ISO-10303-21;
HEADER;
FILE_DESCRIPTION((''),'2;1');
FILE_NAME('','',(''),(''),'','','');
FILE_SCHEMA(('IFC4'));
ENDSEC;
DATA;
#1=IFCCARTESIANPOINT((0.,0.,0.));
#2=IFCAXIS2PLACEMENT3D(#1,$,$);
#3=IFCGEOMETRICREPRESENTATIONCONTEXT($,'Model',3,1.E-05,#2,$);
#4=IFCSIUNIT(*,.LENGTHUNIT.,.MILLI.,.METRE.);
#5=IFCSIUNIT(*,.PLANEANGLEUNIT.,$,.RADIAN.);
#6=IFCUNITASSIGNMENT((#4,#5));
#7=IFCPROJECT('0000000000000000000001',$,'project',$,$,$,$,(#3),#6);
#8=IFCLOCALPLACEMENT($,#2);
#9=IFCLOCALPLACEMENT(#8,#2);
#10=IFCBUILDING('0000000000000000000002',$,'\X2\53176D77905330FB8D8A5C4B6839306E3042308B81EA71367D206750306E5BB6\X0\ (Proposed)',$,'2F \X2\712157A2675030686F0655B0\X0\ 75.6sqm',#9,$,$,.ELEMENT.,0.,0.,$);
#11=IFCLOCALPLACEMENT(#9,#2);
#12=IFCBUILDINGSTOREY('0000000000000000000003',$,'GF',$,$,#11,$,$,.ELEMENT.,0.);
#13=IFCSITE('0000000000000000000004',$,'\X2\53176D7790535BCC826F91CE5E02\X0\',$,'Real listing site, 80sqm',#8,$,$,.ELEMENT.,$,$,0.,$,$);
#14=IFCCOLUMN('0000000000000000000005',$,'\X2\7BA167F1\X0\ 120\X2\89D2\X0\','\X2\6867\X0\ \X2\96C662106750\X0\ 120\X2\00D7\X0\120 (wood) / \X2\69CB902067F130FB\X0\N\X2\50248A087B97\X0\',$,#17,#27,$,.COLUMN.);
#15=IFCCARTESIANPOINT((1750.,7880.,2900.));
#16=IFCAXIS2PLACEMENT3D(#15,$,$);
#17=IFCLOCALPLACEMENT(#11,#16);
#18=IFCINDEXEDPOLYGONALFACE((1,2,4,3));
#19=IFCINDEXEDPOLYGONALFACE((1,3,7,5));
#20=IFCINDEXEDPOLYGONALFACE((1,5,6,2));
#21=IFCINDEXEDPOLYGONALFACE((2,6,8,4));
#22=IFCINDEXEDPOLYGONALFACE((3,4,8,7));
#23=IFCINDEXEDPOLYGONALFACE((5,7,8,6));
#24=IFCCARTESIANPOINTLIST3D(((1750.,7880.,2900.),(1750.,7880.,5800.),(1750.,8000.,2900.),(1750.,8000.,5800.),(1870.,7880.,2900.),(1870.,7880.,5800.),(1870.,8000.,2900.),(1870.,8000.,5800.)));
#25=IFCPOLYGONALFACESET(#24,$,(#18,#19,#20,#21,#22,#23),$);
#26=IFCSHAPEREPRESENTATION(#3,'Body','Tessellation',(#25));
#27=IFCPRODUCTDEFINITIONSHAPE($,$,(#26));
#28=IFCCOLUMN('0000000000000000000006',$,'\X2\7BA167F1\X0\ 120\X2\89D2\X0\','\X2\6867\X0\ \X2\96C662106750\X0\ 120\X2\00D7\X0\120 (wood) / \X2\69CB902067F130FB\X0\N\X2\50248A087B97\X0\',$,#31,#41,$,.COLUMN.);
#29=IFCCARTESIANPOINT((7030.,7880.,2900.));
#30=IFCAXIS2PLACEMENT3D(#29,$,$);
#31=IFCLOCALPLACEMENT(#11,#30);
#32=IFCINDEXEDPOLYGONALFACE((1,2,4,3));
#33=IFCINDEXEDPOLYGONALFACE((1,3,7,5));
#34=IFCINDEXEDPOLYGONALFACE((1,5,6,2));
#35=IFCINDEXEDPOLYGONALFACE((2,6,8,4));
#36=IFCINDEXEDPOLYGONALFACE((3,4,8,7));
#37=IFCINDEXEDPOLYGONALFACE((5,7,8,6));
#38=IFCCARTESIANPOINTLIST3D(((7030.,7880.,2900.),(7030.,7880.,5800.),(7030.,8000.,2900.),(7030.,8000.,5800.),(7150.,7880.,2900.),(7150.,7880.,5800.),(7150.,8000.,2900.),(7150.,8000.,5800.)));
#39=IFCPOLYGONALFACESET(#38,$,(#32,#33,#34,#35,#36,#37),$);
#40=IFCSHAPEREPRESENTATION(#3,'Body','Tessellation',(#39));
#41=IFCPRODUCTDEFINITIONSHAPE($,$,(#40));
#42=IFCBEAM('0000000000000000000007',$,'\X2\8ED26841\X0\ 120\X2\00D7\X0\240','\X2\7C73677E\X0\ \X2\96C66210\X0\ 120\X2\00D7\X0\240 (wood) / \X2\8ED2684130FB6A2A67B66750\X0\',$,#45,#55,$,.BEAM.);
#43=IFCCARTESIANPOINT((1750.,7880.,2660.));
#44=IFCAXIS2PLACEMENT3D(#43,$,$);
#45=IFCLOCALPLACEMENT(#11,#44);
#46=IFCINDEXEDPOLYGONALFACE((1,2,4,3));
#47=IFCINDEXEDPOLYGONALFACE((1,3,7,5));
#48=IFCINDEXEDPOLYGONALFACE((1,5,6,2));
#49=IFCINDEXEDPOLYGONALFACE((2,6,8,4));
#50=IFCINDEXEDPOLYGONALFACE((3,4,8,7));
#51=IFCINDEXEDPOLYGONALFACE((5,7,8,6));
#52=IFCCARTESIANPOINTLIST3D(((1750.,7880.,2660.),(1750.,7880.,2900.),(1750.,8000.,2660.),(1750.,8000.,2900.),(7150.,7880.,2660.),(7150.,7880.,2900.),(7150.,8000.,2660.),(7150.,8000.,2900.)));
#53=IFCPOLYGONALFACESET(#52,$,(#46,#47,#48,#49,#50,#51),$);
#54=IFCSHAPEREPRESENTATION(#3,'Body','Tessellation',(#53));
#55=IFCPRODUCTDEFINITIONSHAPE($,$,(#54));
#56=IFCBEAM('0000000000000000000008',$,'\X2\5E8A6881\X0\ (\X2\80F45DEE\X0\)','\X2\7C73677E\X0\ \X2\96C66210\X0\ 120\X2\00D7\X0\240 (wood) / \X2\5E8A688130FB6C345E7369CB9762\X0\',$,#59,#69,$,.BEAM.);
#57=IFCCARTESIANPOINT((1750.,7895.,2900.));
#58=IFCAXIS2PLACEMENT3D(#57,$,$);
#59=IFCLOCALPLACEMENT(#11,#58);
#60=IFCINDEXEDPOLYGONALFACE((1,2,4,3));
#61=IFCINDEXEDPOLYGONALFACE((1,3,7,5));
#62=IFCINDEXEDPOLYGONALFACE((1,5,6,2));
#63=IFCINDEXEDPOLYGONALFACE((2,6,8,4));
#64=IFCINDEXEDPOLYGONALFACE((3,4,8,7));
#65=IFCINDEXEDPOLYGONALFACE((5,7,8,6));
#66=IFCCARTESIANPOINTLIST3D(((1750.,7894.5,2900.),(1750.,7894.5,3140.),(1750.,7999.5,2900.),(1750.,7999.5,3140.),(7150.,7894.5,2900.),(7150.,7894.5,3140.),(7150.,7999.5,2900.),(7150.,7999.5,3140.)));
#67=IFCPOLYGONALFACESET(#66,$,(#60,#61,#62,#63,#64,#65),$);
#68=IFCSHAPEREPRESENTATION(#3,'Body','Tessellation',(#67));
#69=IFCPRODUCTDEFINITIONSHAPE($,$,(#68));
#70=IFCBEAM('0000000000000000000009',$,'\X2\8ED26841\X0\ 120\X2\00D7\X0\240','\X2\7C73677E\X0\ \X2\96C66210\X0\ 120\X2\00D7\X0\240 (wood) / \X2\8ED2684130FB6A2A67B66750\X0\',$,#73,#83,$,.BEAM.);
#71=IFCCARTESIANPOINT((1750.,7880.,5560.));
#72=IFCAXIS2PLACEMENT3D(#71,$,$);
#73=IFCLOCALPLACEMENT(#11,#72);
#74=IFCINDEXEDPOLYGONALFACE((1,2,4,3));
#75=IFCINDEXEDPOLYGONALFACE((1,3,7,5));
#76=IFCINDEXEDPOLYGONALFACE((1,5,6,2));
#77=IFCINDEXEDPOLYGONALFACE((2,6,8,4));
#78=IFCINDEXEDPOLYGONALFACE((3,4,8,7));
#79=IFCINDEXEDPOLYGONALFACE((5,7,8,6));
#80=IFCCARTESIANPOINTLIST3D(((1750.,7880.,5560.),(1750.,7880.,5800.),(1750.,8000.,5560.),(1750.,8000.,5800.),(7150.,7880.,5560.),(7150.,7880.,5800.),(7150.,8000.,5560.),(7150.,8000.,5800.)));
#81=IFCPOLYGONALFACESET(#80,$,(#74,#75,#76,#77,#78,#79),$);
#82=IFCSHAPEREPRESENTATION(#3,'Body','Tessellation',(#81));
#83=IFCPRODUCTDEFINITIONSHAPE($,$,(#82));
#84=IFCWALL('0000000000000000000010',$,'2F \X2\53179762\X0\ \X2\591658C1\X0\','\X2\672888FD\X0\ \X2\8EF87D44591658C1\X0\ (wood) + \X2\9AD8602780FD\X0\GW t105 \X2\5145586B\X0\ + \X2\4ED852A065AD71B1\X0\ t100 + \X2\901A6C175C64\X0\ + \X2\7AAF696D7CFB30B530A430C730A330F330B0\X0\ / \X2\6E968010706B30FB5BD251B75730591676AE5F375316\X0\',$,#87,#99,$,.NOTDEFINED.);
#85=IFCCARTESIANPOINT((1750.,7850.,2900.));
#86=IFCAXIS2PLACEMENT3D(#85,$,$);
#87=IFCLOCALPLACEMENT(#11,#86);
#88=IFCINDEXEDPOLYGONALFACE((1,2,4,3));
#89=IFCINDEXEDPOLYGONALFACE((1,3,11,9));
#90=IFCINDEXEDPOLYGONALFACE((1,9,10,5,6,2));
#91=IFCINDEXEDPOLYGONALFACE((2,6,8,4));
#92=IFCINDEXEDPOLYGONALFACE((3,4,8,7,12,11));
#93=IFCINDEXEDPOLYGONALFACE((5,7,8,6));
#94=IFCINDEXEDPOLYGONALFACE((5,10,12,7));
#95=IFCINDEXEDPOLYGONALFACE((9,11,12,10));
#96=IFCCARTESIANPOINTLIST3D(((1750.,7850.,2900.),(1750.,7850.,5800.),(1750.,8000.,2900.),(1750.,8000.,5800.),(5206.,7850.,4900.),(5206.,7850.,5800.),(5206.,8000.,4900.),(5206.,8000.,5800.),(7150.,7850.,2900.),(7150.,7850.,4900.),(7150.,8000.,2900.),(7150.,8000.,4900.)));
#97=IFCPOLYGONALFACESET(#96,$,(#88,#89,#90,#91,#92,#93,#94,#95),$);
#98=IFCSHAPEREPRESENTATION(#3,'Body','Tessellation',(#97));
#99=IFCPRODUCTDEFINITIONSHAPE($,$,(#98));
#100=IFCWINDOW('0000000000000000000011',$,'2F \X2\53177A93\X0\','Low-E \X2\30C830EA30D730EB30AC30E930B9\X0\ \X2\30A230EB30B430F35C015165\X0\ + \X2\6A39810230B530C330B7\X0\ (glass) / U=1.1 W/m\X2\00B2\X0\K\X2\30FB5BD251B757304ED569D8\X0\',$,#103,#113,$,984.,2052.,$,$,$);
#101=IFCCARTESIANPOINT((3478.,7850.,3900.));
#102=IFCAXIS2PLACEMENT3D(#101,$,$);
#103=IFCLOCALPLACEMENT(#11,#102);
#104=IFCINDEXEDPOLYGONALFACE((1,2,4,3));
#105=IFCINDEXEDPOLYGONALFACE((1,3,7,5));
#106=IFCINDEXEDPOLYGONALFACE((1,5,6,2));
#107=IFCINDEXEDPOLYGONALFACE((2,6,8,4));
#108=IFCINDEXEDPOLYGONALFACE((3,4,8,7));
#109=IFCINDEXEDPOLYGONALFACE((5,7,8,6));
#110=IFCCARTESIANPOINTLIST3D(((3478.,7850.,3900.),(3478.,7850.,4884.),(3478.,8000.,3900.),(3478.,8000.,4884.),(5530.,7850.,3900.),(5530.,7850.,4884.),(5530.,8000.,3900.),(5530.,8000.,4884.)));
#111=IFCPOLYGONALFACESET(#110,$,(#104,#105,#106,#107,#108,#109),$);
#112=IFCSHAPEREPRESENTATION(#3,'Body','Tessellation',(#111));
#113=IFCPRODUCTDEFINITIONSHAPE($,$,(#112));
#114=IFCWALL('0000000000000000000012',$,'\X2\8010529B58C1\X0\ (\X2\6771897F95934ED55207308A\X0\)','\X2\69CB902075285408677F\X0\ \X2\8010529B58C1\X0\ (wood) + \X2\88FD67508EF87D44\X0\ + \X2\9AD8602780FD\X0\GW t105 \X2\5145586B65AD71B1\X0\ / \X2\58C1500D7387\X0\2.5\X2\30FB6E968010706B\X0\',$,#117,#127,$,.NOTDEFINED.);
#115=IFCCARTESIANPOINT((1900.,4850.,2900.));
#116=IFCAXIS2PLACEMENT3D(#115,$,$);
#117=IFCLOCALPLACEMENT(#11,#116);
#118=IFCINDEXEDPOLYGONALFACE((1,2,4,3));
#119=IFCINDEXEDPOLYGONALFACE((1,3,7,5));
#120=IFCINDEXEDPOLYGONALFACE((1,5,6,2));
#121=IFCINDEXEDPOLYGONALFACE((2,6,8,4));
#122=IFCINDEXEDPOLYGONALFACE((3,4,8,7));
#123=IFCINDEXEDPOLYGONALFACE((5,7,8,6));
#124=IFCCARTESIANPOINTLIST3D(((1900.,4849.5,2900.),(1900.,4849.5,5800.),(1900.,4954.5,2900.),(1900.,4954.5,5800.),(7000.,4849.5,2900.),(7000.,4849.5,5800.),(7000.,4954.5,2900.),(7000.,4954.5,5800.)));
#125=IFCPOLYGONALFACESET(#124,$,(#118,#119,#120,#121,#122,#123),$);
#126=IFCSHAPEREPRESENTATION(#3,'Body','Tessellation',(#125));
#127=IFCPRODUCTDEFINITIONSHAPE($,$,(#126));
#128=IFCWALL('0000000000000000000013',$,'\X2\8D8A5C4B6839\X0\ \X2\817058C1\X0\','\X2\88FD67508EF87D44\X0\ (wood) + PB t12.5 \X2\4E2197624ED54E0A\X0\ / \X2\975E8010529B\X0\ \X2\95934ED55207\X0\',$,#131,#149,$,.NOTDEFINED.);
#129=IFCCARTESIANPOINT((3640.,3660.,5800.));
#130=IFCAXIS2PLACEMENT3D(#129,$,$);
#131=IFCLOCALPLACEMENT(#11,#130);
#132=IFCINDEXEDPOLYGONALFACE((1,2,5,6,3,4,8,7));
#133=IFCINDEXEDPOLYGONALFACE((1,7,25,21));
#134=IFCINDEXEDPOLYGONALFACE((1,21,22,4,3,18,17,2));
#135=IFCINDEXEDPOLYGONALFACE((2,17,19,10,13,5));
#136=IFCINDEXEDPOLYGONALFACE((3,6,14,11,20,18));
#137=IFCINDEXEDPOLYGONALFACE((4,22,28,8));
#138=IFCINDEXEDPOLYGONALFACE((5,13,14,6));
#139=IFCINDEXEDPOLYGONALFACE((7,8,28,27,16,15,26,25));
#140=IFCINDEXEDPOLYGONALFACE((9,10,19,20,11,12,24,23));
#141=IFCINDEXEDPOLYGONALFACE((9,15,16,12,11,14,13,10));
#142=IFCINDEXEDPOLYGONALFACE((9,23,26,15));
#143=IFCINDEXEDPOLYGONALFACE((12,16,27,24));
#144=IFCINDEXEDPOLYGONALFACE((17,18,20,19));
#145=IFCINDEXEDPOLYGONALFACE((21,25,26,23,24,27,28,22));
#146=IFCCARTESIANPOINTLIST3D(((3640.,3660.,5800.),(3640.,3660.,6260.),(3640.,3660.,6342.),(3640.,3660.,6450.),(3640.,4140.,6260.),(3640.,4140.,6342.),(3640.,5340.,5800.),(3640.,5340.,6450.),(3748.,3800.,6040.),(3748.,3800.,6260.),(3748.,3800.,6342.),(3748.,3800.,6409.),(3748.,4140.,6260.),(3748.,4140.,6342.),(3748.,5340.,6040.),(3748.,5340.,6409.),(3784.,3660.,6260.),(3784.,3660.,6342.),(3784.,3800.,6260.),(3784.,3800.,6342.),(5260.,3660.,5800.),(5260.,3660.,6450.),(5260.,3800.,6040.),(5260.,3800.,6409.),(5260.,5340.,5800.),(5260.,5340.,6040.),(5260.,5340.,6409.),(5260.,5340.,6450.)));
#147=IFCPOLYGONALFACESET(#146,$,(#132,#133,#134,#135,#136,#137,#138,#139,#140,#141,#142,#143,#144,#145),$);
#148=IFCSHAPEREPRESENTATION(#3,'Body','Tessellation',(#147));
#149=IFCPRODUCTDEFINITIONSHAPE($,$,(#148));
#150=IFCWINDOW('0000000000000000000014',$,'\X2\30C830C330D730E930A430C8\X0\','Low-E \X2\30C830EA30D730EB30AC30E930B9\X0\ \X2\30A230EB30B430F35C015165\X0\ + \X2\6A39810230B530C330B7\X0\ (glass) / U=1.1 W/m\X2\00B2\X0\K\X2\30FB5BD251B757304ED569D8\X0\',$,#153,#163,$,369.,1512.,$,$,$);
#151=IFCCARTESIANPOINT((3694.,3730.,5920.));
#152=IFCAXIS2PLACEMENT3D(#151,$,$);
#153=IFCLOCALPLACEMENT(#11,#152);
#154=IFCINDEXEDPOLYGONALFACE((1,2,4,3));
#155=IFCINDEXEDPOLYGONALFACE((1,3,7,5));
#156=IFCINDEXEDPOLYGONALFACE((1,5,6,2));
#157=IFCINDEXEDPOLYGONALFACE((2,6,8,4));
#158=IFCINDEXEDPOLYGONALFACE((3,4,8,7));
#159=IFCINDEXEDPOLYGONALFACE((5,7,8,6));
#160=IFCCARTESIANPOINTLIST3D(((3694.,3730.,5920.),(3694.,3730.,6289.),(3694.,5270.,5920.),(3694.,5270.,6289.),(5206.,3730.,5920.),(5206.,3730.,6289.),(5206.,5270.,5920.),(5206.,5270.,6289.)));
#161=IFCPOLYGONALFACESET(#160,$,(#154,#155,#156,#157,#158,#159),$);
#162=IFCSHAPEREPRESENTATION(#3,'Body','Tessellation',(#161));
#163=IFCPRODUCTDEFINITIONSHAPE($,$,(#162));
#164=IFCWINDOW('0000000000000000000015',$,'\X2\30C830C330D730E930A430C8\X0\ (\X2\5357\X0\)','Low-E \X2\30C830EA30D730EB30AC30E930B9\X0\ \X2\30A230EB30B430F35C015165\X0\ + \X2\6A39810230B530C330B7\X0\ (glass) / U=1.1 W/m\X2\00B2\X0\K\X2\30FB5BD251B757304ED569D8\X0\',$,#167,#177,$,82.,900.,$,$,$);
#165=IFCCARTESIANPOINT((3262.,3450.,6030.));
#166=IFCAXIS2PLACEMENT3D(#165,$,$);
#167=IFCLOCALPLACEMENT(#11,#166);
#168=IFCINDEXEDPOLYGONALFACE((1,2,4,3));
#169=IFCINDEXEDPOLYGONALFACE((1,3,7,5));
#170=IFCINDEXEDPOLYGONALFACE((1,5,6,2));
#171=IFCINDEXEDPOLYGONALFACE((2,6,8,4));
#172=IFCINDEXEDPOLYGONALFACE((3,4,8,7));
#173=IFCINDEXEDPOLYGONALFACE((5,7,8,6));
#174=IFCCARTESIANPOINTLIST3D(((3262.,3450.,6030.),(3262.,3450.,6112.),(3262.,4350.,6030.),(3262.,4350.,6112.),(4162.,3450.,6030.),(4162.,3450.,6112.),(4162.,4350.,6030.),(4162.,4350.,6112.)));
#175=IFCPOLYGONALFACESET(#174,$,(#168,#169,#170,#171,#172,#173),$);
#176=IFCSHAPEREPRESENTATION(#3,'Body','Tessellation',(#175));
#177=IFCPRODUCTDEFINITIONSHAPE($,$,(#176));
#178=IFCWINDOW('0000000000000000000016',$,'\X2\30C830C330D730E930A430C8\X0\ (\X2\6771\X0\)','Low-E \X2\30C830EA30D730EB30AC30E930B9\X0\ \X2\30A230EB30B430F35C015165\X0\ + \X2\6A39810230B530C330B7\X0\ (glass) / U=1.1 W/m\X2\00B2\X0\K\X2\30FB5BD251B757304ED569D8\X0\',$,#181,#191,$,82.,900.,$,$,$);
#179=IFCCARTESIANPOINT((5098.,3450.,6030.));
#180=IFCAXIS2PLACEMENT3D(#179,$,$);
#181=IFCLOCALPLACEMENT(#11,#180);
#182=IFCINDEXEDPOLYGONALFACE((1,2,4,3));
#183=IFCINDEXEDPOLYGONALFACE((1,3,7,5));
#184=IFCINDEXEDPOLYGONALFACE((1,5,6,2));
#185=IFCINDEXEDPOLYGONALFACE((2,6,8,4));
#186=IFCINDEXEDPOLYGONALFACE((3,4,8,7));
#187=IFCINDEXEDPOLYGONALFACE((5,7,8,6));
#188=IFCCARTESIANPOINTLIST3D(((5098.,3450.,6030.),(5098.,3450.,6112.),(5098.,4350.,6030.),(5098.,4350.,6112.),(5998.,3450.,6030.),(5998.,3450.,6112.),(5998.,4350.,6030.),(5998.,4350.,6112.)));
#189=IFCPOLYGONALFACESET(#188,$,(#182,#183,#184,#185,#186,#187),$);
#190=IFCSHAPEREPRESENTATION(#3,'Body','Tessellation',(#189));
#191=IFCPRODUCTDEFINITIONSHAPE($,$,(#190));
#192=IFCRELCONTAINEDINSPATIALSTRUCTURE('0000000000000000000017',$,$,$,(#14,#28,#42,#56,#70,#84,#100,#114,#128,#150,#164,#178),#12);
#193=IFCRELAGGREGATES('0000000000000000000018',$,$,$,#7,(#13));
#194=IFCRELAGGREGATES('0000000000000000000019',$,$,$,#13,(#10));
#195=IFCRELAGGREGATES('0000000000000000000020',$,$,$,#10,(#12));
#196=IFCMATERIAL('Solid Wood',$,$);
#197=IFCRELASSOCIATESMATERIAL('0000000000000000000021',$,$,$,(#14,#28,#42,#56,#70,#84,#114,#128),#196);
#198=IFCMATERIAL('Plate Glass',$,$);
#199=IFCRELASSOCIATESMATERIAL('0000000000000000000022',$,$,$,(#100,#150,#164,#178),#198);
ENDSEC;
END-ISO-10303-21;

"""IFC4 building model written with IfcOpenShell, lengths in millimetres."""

from ifc_helpers import new_model, si_unit, frame, frame_2d, origin, place, context, project, spatial, rectangle, extrude, material, element, fill, save


model = new_model("IFC4")

# Units and contexts
model_context = context("Model", 3, precision=1e-05, world=origin())
ifc_project = project(units=[si_unit("LENGTHUNIT", "METRE", prefix="MILLI"), si_unit("PLANEANGLEUNIT", "RADIAN")], contexts=[model_context])

# Site, building, storey
site_placement = place(None, origin())
site = spatial("IfcSite", under=ifc_project, at=site_placement, Name="北海道富良野市", ObjectType="Real listing site, 80sqm", CompositionType="ELEMENT", RefElevation=0.0)
building_placement = place(site_placement, origin())
building = spatial("IfcBuilding", under=site, at=building_placement, Name="北海道・越屋根のある自然素材の家 (Proposed)", ObjectType="2F 無垢材と漆喰 75.6sqm", CompositionType="ELEMENT", ElevationOfRefHeight=0.0, ElevationOfTerrain=0.0)
storey_placement = place(building_placement, origin())
storey = spatial("IfcBuildingStorey", under=building, at=storey_placement, Name="GF", CompositionType="ELEMENT", Elevation=0.0)

# Columns
ifc_material_1 = material(Name="Solid Wood")
column_1_placement = place(storey_placement, frame((1750.0, 7880.0, 2900.0)))
element("IfcColumn", 1, at=column_1_placement, inside=storey, material=ifc_material_1, Name="管柱 120角", Description="桧 集成材 120×120 (wood) / 構造柱・N値計算", PredefinedType="COLUMN", context=model_context, shape_type="SweptSolid", body=[
    extrude(rectangle(XDim=120.0, YDim=120.0, at=frame_2d((60.0, 60.0))), frame((1750.0, 7880.0, 2900.0)), (0.0, 0.0, 1.0), 2900.0),
])
column_2_placement = place(storey_placement, frame((7030.0, 7880.0, 2900.0)))
element("IfcColumn", 2, at=column_2_placement, inside=storey, material=ifc_material_1, Name="管柱 120角", Description="桧 集成材 120×120 (wood) / 構造柱・N値計算", PredefinedType="COLUMN", context=model_context, shape_type="SweptSolid", body=[
    extrude(rectangle(XDim=120.0, YDim=120.0, at=frame_2d((60.0, 60.0))), frame((7030.0, 7880.0, 2900.0)), (0.0, 0.0, 1.0), 2900.0),
])

# Beams
beam_1_placement = place(storey_placement, frame((1750.0, 7880.0, 2660.0)))
element("IfcBeam", 3, at=beam_1_placement, inside=storey, material=ifc_material_1, Name="軒桁 120×240", Description="米松 集成 120×240 (wood) / 軒桁・横架材", PredefinedType="BEAM", context=model_context, shape_type="SweptSolid", body=[
    extrude(rectangle(XDim=5400.0, YDim=120.0, at=frame_2d((2700.0, 60.0))), frame((1750.0, 7880.0, 2660.0)), (0.0, 0.0, 1.0), 240.0),
])
beam_2_placement = place(storey_placement, frame((1750.0, 7895.0, 2900.0)))
element("IfcBeam", 4, at=beam_2_placement, inside=storey, material=ifc_material_1, Name="床梁 (胴差)", Description="米松 集成 120×240 (wood) / 床梁・水平構面", PredefinedType="BEAM", context=model_context, shape_type="SweptSolid", body=[
    extrude(rectangle(XDim=5400.0, YDim=105.0, at=frame_2d((2700.0, 52.0))), frame((1750.0, 7895.0, 2900.0)), (0.0, 0.0, 1.0), 240.0),
])
beam_3_placement = place(storey_placement, frame((1750.0, 7880.0, 5560.0)))
element("IfcBeam", 5, at=beam_3_placement, inside=storey, material=ifc_material_1, Name="軒桁 120×240", Description="米松 集成 120×240 (wood) / 軒桁・横架材", PredefinedType="BEAM", context=model_context, shape_type="SweptSolid", body=[
    extrude(rectangle(XDim=5400.0, YDim=120.0, at=frame_2d((2700.0, 60.0))), frame((1750.0, 7880.0, 5560.0)), (0.0, 0.0, 1.0), 240.0),
])

# Wall, opening, window
wall_1_placement = place(storey_placement, frame((1750.0, 7850.0, 2900.0)))
wall_1 = element("IfcWall", 6, at=wall_1_placement, inside=storey, material=ifc_material_1, Name="2F 北面 外壁", Description="木製 軸組外壁 (wood) + 高性能GW t105 充填 + 付加断熱 t100 + 通気層 + 窯業系サイディング / 準耐火・寒冷地外皮強化", PredefinedType="NOTDEFINED", context=model_context, shape_type="SweptSolid", body=[
    extrude(rectangle(XDim=5400.0, YDim=150.0, at=frame_2d((2700.0, 75.0))), frame((1750.0, 7850.0, 2900.0)), (0.0, 0.0, 1.0), 2900.0),
])
opening_1_placement = place(storey_placement, frame((3478.0, 7850.0, 3900.0)))
opening_1 = element("IfcOpeningElement", 7, at=opening_1_placement, cuts=wall_1, PredefinedType="NOTDEFINED", context=model_context, shape_type="SweptSolid", body=[
    extrude(rectangle(XDim=2052.0, YDim=150.0, at=frame_2d((1026.0, 75.0))), frame((3478.0, 7850.0, 3900.0)), (0.0, 0.0, 1.0), 984.0),
])
ifc_material_2 = material(Name="Plate Glass")
window_1_placement = place(storey_placement, frame((3478.0, 7850.0, 3900.0)))
window_1 = element("IfcWindow", 8, at=window_1_placement, inside=storey, material=ifc_material_2, Name="2F 北窓", Description="Low-E トリプルガラス アルゴン封入 + 樹脂サッシ (glass) / U=1.1 W/m²K・寒冷地仕様", OverallHeight=984.0, OverallWidth=2052.0, context=model_context, shape_type="SweptSolid", body=[
    extrude(rectangle(XDim=2052.0, YDim=150.0, at=frame_2d((1026.0, 75.0))), frame((3478.0, 7850.0, 3900.0)), (0.0, 0.0, 1.0), 984.0),
])
fill(opening_1, window_1)

# Wall
wall_2_placement = place(storey_placement, frame((1900.0, 4850.0, 2900.0)))
element("IfcWall", 9, at=wall_2_placement, inside=storey, material=ifc_material_1, Name="耐力壁 (東西間仕切り)", Description="構造用合板 耐力壁 (wood) + 製材軸組 + 高性能GW t105 充填断熱 / 壁倍率2.5・準耐火", PredefinedType="NOTDEFINED", context=model_context, shape_type="SweptSolid", body=[
    extrude(rectangle(XDim=5100.0, YDim=105.0, at=frame_2d((2550.0, 52.0))), frame((1900.0, 4850.0, 2900.0)), (0.0, 0.0, 1.0), 2900.0),
])

# Wall, openings, windows
wall_3_placement = place(storey_placement, frame((3640.0, 3660.0, 5800.0)))
wall_3 = element("IfcWall", 10, at=wall_3_placement, inside=storey, material=ifc_material_1, Name="越屋根 腰壁", Description="製材軸組 (wood) + PB t12.5 両面仕上 / 非耐力 間仕切", PredefinedType="NOTDEFINED", context=model_context, shape_type="SweptSolid", body=[
    extrude(rectangle(XDim=1620.0, YDim=1680.0, at=frame_2d((810.0, 840.0))), frame((3640.0, 3660.0, 5800.0)), (0.0, 0.0, 1.0), 650.0),
])
opening_2_placement = place(storey_placement, frame((3694.0, 3730.0, 5920.0)))
opening_2 = element("IfcOpeningElement", 11, at=opening_2_placement, cuts=wall_3, PredefinedType="NOTDEFINED", context=model_context, shape_type="SweptSolid", body=[
    extrude(rectangle(XDim=1512.0, YDim=1540.0, at=frame_2d((756.0, 770.0))), frame((3694.0, 3730.0, 5920.0)), (0.0, 0.0, 1.0), 369.0),
])
opening_3_placement = place(storey_placement, frame((3262.0, 3450.0, 6030.0)))
opening_3 = element("IfcOpeningElement", 12, at=opening_3_placement, cuts=wall_3, PredefinedType="NOTDEFINED", context=model_context, shape_type="SweptSolid", body=[
    extrude(rectangle(XDim=900.0, YDim=900.0, at=frame_2d((450.0, 450.0))), frame((3262.0, 3450.0, 6030.0)), (0.0, 0.0, 1.0), 82.0),
])
opening_4_placement = place(storey_placement, frame((5098.0, 3450.0, 6030.0)))
opening_4 = element("IfcOpeningElement", 13, at=opening_4_placement, cuts=wall_3, PredefinedType="NOTDEFINED", context=model_context, shape_type="SweptSolid", body=[
    extrude(rectangle(XDim=900.0, YDim=900.0, at=frame_2d((450.0, 450.0))), frame((5098.0, 3450.0, 6030.0)), (0.0, 0.0, 1.0), 82.0),
])
window_2_placement = place(storey_placement, frame((3694.0, 3730.0, 5920.0)))
window_2 = element("IfcWindow", 14, at=window_2_placement, inside=storey, material=ifc_material_2, Name="トップライト", Description="Low-E トリプルガラス アルゴン封入 + 樹脂サッシ (glass) / U=1.1 W/m²K・寒冷地仕様", OverallHeight=369.0, OverallWidth=1512.0, context=model_context, shape_type="SweptSolid", body=[
    extrude(rectangle(XDim=1512.0, YDim=1540.0, at=frame_2d((756.0, 770.0))), frame((3694.0, 3730.0, 5920.0)), (0.0, 0.0, 1.0), 369.0),
])
fill(opening_2, window_2)
window_3_placement = place(storey_placement, frame((3262.0, 3450.0, 6030.0)))
window_3 = element("IfcWindow", 15, at=window_3_placement, inside=storey, material=ifc_material_2, Name="トップライト (南)", Description="Low-E トリプルガラス アルゴン封入 + 樹脂サッシ (glass) / U=1.1 W/m²K・寒冷地仕様", OverallHeight=82.0, OverallWidth=900.0, context=model_context, shape_type="SweptSolid", body=[
    extrude(rectangle(XDim=900.0, YDim=900.0, at=frame_2d((450.0, 450.0))), frame((3262.0, 3450.0, 6030.0)), (0.0, 0.0, 1.0), 82.0),
])
fill(opening_3, window_3)
window_4_placement = place(storey_placement, frame((5098.0, 3450.0, 6030.0)))
window_4 = element("IfcWindow", 16, at=window_4_placement, inside=storey, material=ifc_material_2, Name="トップライト (東)", Description="Low-E トリプルガラス アルゴン封入 + 樹脂サッシ (glass) / U=1.1 W/m²K・寒冷地仕様", OverallHeight=82.0, OverallWidth=900.0, context=model_context, shape_type="SweptSolid", body=[
    extrude(rectangle(XDim=900.0, YDim=900.0, at=frame_2d((450.0, 450.0))), frame((5098.0, 3450.0, 6030.0)), (0.0, 0.0, 1.0), 82.0),
])
fill(opening_4, window_4)

save(model, "model.ifc")
